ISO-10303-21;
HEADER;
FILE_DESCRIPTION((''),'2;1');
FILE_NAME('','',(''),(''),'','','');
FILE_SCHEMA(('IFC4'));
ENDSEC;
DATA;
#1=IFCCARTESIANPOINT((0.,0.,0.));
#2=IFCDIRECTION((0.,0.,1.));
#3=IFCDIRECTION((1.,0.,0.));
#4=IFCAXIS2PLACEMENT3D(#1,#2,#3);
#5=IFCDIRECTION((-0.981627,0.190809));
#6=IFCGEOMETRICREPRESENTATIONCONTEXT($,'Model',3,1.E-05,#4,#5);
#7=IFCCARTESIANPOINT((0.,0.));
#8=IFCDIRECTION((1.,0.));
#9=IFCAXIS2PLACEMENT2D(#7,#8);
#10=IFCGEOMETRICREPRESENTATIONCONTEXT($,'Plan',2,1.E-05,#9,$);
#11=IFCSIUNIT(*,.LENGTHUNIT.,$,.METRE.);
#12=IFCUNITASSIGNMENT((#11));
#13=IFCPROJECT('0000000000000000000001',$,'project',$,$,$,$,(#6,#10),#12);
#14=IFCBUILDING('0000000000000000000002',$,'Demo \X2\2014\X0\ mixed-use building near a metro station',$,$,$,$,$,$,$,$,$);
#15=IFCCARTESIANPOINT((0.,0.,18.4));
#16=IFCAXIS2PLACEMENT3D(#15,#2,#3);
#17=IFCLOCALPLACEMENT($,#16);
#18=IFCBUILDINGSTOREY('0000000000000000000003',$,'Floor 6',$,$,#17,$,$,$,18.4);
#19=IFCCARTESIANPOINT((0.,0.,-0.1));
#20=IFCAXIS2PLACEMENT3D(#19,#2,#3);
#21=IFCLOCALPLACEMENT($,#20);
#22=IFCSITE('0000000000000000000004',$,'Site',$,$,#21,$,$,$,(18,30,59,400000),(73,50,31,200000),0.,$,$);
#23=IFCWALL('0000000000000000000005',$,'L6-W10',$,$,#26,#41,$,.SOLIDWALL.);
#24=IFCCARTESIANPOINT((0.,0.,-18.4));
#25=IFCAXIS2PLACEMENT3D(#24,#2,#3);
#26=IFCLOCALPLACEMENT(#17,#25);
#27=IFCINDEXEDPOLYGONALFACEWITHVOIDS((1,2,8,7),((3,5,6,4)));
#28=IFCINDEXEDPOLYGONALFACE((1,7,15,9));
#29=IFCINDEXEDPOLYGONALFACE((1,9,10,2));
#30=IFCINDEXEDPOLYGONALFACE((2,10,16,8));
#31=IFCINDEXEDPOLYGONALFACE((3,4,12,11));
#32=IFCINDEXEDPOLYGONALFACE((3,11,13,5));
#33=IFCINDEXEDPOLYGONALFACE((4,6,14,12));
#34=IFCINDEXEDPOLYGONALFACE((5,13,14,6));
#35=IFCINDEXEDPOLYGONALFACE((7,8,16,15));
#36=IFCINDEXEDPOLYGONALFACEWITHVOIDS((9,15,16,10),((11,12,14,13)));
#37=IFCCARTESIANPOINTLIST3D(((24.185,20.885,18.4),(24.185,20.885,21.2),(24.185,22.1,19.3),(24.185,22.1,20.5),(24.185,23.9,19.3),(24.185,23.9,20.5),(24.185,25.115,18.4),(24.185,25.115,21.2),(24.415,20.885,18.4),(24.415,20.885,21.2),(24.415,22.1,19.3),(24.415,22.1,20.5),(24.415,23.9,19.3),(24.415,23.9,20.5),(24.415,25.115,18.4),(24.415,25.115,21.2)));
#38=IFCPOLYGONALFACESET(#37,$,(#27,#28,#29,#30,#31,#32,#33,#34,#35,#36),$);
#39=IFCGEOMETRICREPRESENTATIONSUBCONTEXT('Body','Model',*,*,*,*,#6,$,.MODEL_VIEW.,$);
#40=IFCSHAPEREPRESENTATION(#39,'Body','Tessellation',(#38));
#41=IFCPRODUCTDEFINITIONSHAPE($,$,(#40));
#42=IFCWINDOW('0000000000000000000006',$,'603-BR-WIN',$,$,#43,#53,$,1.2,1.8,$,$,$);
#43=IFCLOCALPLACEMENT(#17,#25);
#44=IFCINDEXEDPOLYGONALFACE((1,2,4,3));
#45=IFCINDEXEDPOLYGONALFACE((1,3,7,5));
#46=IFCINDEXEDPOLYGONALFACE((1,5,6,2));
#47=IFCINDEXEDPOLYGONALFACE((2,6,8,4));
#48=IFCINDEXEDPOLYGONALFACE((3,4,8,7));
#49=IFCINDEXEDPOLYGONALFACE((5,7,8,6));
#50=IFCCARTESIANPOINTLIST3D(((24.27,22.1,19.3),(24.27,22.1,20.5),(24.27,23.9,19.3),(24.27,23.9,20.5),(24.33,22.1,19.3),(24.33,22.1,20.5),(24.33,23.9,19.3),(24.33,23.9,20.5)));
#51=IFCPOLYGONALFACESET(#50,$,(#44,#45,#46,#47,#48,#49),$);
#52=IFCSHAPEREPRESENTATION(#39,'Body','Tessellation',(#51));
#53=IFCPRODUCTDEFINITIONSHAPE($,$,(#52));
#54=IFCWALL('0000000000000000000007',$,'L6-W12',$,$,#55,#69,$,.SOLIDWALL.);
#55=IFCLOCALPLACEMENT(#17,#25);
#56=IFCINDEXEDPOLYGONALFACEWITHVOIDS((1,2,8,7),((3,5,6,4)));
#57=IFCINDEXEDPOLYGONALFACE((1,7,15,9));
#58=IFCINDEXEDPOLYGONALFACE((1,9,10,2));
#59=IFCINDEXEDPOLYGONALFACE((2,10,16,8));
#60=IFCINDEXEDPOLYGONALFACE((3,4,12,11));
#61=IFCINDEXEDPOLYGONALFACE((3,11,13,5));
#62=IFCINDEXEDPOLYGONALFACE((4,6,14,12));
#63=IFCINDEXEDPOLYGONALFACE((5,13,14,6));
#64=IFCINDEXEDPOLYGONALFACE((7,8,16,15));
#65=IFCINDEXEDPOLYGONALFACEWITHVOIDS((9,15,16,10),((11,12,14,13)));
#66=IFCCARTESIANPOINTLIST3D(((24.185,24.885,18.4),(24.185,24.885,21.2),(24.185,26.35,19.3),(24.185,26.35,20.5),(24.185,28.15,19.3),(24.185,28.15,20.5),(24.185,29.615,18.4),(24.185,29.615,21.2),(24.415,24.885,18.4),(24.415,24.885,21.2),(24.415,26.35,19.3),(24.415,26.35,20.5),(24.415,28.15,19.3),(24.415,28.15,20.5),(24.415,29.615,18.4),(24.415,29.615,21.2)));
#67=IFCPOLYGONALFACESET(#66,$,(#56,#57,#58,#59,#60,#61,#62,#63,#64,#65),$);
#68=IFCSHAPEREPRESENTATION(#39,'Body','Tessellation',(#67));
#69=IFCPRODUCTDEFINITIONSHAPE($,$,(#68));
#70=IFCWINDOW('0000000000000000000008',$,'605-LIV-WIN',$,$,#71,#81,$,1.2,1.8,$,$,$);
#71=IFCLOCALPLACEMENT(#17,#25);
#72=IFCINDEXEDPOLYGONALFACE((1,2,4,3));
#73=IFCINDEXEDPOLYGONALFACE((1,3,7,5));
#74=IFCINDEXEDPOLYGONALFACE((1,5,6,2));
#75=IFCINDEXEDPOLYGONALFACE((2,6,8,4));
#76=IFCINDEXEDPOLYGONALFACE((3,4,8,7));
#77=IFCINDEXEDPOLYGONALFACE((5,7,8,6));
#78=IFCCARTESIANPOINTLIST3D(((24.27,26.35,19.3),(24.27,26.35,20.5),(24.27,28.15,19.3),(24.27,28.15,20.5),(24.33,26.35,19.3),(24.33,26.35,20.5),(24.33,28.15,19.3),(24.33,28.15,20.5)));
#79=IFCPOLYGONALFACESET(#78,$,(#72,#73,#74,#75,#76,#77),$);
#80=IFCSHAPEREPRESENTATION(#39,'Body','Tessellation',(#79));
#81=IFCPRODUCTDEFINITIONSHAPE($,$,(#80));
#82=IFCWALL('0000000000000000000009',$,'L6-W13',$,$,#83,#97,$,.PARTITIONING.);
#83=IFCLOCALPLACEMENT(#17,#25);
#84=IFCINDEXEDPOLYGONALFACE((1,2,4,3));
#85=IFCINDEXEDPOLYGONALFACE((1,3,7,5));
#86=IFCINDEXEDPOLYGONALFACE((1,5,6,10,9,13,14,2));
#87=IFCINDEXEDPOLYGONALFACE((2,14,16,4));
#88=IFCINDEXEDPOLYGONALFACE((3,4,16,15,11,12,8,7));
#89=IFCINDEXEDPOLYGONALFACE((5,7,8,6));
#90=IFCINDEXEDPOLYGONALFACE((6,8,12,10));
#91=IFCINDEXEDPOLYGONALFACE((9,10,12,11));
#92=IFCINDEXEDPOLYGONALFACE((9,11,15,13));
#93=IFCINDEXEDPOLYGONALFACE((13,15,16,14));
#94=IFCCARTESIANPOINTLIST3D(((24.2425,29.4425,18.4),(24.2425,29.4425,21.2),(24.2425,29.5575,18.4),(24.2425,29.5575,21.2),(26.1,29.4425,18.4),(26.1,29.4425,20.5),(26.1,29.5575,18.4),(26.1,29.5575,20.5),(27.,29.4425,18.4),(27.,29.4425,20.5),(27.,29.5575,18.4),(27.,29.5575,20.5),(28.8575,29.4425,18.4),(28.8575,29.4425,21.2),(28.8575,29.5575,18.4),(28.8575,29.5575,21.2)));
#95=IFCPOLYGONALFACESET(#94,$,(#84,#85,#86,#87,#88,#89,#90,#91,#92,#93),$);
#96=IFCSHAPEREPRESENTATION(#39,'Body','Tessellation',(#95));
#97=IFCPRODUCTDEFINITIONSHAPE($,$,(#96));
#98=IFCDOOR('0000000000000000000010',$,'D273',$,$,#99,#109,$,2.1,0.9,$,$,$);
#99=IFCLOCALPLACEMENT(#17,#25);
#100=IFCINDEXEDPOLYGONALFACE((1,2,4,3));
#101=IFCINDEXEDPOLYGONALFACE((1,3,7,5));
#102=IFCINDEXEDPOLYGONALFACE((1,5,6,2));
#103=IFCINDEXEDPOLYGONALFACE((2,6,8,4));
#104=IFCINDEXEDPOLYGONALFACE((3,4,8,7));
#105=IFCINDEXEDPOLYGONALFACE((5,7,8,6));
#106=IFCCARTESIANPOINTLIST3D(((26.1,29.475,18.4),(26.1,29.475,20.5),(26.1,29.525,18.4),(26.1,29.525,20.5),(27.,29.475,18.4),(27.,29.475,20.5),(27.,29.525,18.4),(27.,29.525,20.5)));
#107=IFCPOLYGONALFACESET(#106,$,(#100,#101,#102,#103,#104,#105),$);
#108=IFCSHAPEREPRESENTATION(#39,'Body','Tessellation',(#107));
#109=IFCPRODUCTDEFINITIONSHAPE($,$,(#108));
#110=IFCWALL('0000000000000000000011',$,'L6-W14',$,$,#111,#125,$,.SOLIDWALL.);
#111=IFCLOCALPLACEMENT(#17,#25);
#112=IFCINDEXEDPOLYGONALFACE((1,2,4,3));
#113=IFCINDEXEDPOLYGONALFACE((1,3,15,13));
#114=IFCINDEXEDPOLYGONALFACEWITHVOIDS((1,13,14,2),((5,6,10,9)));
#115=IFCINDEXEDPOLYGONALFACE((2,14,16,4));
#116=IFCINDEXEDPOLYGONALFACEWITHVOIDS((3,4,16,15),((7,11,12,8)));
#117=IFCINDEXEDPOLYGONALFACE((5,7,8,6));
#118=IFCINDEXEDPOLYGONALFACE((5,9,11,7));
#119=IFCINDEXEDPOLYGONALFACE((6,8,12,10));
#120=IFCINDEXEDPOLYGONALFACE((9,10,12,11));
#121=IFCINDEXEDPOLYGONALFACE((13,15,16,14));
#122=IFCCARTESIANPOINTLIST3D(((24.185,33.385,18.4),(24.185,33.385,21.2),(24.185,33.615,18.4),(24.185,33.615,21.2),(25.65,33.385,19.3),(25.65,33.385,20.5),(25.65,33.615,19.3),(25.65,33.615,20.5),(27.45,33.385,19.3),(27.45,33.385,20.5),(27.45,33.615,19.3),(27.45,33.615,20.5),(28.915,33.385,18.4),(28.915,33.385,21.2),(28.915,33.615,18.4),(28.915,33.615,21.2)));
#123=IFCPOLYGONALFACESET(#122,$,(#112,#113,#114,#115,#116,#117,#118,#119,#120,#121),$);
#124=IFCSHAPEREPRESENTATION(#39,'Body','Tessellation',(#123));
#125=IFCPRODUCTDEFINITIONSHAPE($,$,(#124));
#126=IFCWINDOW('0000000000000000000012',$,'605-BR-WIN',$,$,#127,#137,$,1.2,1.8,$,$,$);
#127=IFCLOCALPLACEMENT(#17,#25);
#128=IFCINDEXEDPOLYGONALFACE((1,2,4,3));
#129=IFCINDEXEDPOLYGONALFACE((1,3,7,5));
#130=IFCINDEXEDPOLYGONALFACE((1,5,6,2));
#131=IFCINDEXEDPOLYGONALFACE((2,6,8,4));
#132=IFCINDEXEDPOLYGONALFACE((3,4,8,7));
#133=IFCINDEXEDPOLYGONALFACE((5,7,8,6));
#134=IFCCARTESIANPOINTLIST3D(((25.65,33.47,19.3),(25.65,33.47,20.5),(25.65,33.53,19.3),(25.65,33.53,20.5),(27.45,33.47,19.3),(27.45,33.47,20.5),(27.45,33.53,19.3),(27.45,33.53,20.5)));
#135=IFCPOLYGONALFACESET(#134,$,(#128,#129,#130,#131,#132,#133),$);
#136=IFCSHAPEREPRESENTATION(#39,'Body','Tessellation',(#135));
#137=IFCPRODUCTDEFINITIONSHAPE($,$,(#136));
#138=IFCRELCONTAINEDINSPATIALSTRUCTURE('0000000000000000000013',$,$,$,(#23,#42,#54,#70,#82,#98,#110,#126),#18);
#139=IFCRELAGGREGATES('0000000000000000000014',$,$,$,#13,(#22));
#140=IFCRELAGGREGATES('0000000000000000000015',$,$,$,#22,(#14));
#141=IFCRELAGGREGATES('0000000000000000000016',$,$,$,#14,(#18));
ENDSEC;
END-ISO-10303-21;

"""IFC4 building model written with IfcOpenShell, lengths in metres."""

from ifc_helpers import new_model, si_unit, direction, frame, origin_with_axes, origin_2d_with_axis, place, context, subcontext, project, spatial, line, indexed_curve, outline, extrude, element, fill, save


model = new_model("IFC4")

# Units and contexts
model_context = context("Model", 3, precision=1e-05, world=origin_with_axes(), true_north=direction((-0.981627, 0.190809)))
plan_context = context("Plan", 2, precision=1e-05, world=origin_2d_with_axis())
body_context = subcontext(model_context, "Body", "Model", "MODEL_VIEW")
ifc_project = project(units=[si_unit("LENGTHUNIT", "METRE")], contexts=[model_context, plan_context])

# Site, building, storey
site_placement = place(None, frame((0.0, 0.0, -0.1), z_axis=(0.0, 0.0, 1.0), x_axis=(1.0, 0.0, 0.0)))
site = spatial("IfcSite", under=ifc_project, at=site_placement, Name="Site", RefLatitude=(18, 30, 59, 400000), RefLongitude=(73, 50, 31, 200000), RefElevation=0.0)
building = spatial("IfcBuilding", under=site, Name="Demo — mixed-use building near a metro station")
storey_placement = place(None, frame((0.0, 0.0, 18.4), z_axis=(0.0, 0.0, 1.0), x_axis=(1.0, 0.0, 0.0)))
storey = spatial("IfcBuildingStorey", under=building, at=storey_placement, Name="Floor 6", Elevation=18.4)

# Wall, opening, window
wall_1_placement = place(storey_placement, frame((0.0, 0.0, -18.4), z_axis=(0.0, 0.0, 1.0), x_axis=(1.0, 0.0, 0.0)))
wall_1 = element("IfcWall", 1, at=wall_1_placement, inside=storey, Name="L6-W10", PredefinedType="SOLIDWALL", context=body_context, shape_type="SweptSolid", body=[
    extrude(outline(indexed_curve([(24.415, 25.115), (24.415, 20.885), (24.185, 20.885), (24.185, 25.115)], segments=[line(1, 2, 3, 4, 1)])), frame((0.0, 0.0, 18.4), z_axis=(0.0, 0.0, 1.0), x_axis=(1.0, 0.0, 0.0)), (0.0, 0.0, 1.0), 2.8),
])
opening_1_placement = place(wall_1_placement, origin_with_axes())
opening_1 = element("IfcOpeningElement", 2, at=opening_1_placement, cuts=wall_1, context=body_context, shape_type="SweptSolid", body=[
    extrude(outline(indexed_curve([(24.465, 23.9), (24.465, 22.1), (24.135, 22.1), (24.135, 23.9)], segments=[line(1, 2, 3, 4, 1)])), frame((0.0, 0.0, 19.3), z_axis=(0.0, 0.0, 1.0), x_axis=(1.0, 0.0, 0.0)), (0.0, 0.0, 1.0), 1.2),
])
window_1_placement = place(storey_placement, frame((0.0, 0.0, -18.4), z_axis=(0.0, 0.0, 1.0), x_axis=(1.0, 0.0, 0.0)))
window_1 = element("IfcWindow", 3, at=window_1_placement, inside=storey, Name="603-BR-WIN", OverallHeight=1.2, OverallWidth=1.8, context=body_context, shape_type="SweptSolid", body=[
    extrude(outline(indexed_curve([(24.33, 23.9), (24.33, 22.1), (24.27, 22.1), (24.27, 23.9)], segments=[line(1, 2, 3, 4, 1)])), frame((0.0, 0.0, 19.3), z_axis=(0.0, 0.0, 1.0), x_axis=(1.0, 0.0, 0.0)), (0.0, 0.0, 1.0), 1.2),
])
fill(opening_1, window_1)

# Wall, opening, window
wall_2_placement = place(storey_placement, frame((0.0, 0.0, -18.4), z_axis=(0.0, 0.0, 1.0), x_axis=(1.0, 0.0, 0.0)))
wall_2 = element("IfcWall", 4, at=wall_2_placement, inside=storey, Name="L6-W12", PredefinedType="SOLIDWALL", context=body_context, shape_type="SweptSolid", body=[
    extrude(outline(indexed_curve([(24.415, 29.615), (24.415, 24.885), (24.185, 24.885), (24.185, 29.615)], segments=[line(1, 2, 3, 4, 1)])), frame((0.0, 0.0, 18.4), z_axis=(0.0, 0.0, 1.0), x_axis=(1.0, 0.0, 0.0)), (0.0, 0.0, 1.0), 2.8),
])
opening_2_placement = place(wall_2_placement, origin_with_axes())
opening_2 = element("IfcOpeningElement", 5, at=opening_2_placement, cuts=wall_2, context=body_context, shape_type="SweptSolid", body=[
    extrude(outline(indexed_curve([(24.465, 28.15), (24.465, 26.35), (24.135, 26.35), (24.135, 28.15)], segments=[line(1, 2, 3, 4, 1)])), frame((0.0, 0.0, 19.3), z_axis=(0.0, 0.0, 1.0), x_axis=(1.0, 0.0, 0.0)), (0.0, 0.0, 1.0), 1.2),
])
window_2_placement = place(storey_placement, frame((0.0, 0.0, -18.4), z_axis=(0.0, 0.0, 1.0), x_axis=(1.0, 0.0, 0.0)))
window_2 = element("IfcWindow", 6, at=window_2_placement, inside=storey, Name="605-LIV-WIN", OverallHeight=1.2, OverallWidth=1.8, context=body_context, shape_type="SweptSolid", body=[
    extrude(outline(indexed_curve([(24.33, 28.15), (24.33, 26.35), (24.27, 26.35), (24.27, 28.15)], segments=[line(1, 2, 3, 4, 1)])), frame((0.0, 0.0, 19.3), z_axis=(0.0, 0.0, 1.0), x_axis=(1.0, 0.0, 0.0)), (0.0, 0.0, 1.0), 1.2),
])
fill(opening_2, window_2)

# Wall, opening, door
wall_3_placement = place(storey_placement, frame((0.0, 0.0, -18.4), z_axis=(0.0, 0.0, 1.0), x_axis=(1.0, 0.0, 0.0)))
wall_3 = element("IfcWall", 7, at=wall_3_placement, inside=storey, Name="L6-W13", PredefinedType="PARTITIONING", context=body_context, shape_type="SweptSolid", body=[
    extrude(outline(indexed_curve([(28.8575, 29.4425), (24.2425, 29.4425), (24.2425, 29.5575), (28.8575, 29.5575)], segments=[line(1, 2, 3, 4, 1)])), frame((0.0, 0.0, 18.4), z_axis=(0.0, 0.0, 1.0), x_axis=(1.0, 0.0, 0.0)), (0.0, 0.0, 1.0), 2.8),
])
opening_3_placement = place(wall_3_placement, origin_with_axes())
opening_3 = element("IfcOpeningElement", 8, at=opening_3_placement, cuts=wall_3, context=body_context, shape_type="SweptSolid", body=[
    extrude(outline(indexed_curve([(27.0, 29.3925), (26.1, 29.3925), (26.1, 29.6075), (27.0, 29.6075)], segments=[line(1, 2, 3, 4, 1)])), frame((0.0, 0.0, 18.4), z_axis=(0.0, 0.0, 1.0), x_axis=(1.0, 0.0, 0.0)), (0.0, 0.0, 1.0), 2.1),
])
door_1_placement = place(storey_placement, frame((0.0, 0.0, -18.4), z_axis=(0.0, 0.0, 1.0), x_axis=(1.0, 0.0, 0.0)))
door_1 = element("IfcDoor", 9, at=door_1_placement, inside=storey, Name="D273", OverallHeight=2.1, OverallWidth=0.9, context=body_context, shape_type="SweptSolid", body=[
    extrude(outline(indexed_curve([(27.0, 29.475), (26.1, 29.475), (26.1, 29.525), (27.0, 29.525)], segments=[line(1, 2, 3, 4, 1)])), frame((0.0, 0.0, 18.4), z_axis=(0.0, 0.0, 1.0), x_axis=(1.0, 0.0, 0.0)), (0.0, 0.0, 1.0), 2.1),
])
fill(opening_3, door_1)

# Wall, opening, window
wall_4_placement = place(storey_placement, frame((0.0, 0.0, -18.4), z_axis=(0.0, 0.0, 1.0), x_axis=(1.0, 0.0, 0.0)))
wall_4 = element("IfcWall", 10, at=wall_4_placement, inside=storey, Name="L6-W14", PredefinedType="SOLIDWALL", context=body_context, shape_type="SweptSolid", body=[
    extrude(outline(indexed_curve([(28.915, 33.385), (24.185, 33.385), (24.185, 33.615), (28.915, 33.615)], segments=[line(1, 2, 3, 4, 1)])), frame((0.0, 0.0, 18.4), z_axis=(0.0, 0.0, 1.0), x_axis=(1.0, 0.0, 0.0)), (0.0, 0.0, 1.0), 2.8),
])
opening_4_placement = place(wall_4_placement, origin_with_axes())
opening_4 = element("IfcOpeningElement", 11, at=opening_4_placement, cuts=wall_4, context=body_context, shape_type="SweptSolid", body=[
    extrude(outline(indexed_curve([(27.45, 33.335), (25.65, 33.335), (25.65, 33.665), (27.45, 33.665)], segments=[line(1, 2, 3, 4, 1)])), frame((0.0, 0.0, 19.3), z_axis=(0.0, 0.0, 1.0), x_axis=(1.0, 0.0, 0.0)), (0.0, 0.0, 1.0), 1.2),
])
window_3_placement = place(storey_placement, frame((0.0, 0.0, -18.4), z_axis=(0.0, 0.0, 1.0), x_axis=(1.0, 0.0, 0.0)))
window_3 = element("IfcWindow", 12, at=window_3_placement, inside=storey, Name="605-BR-WIN", OverallHeight=1.2, OverallWidth=1.8, context=body_context, shape_type="SweptSolid", body=[
    extrude(outline(indexed_curve([(27.45, 33.47), (25.65, 33.47), (25.65, 33.53), (27.45, 33.53)], segments=[line(1, 2, 3, 4, 1)])), frame((0.0, 0.0, 19.3), z_axis=(0.0, 0.0, 1.0), x_axis=(1.0, 0.0, 0.0)), (0.0, 0.0, 1.0), 1.2),
])
fill(opening_4, window_3)

save(model, "model.ifc")
